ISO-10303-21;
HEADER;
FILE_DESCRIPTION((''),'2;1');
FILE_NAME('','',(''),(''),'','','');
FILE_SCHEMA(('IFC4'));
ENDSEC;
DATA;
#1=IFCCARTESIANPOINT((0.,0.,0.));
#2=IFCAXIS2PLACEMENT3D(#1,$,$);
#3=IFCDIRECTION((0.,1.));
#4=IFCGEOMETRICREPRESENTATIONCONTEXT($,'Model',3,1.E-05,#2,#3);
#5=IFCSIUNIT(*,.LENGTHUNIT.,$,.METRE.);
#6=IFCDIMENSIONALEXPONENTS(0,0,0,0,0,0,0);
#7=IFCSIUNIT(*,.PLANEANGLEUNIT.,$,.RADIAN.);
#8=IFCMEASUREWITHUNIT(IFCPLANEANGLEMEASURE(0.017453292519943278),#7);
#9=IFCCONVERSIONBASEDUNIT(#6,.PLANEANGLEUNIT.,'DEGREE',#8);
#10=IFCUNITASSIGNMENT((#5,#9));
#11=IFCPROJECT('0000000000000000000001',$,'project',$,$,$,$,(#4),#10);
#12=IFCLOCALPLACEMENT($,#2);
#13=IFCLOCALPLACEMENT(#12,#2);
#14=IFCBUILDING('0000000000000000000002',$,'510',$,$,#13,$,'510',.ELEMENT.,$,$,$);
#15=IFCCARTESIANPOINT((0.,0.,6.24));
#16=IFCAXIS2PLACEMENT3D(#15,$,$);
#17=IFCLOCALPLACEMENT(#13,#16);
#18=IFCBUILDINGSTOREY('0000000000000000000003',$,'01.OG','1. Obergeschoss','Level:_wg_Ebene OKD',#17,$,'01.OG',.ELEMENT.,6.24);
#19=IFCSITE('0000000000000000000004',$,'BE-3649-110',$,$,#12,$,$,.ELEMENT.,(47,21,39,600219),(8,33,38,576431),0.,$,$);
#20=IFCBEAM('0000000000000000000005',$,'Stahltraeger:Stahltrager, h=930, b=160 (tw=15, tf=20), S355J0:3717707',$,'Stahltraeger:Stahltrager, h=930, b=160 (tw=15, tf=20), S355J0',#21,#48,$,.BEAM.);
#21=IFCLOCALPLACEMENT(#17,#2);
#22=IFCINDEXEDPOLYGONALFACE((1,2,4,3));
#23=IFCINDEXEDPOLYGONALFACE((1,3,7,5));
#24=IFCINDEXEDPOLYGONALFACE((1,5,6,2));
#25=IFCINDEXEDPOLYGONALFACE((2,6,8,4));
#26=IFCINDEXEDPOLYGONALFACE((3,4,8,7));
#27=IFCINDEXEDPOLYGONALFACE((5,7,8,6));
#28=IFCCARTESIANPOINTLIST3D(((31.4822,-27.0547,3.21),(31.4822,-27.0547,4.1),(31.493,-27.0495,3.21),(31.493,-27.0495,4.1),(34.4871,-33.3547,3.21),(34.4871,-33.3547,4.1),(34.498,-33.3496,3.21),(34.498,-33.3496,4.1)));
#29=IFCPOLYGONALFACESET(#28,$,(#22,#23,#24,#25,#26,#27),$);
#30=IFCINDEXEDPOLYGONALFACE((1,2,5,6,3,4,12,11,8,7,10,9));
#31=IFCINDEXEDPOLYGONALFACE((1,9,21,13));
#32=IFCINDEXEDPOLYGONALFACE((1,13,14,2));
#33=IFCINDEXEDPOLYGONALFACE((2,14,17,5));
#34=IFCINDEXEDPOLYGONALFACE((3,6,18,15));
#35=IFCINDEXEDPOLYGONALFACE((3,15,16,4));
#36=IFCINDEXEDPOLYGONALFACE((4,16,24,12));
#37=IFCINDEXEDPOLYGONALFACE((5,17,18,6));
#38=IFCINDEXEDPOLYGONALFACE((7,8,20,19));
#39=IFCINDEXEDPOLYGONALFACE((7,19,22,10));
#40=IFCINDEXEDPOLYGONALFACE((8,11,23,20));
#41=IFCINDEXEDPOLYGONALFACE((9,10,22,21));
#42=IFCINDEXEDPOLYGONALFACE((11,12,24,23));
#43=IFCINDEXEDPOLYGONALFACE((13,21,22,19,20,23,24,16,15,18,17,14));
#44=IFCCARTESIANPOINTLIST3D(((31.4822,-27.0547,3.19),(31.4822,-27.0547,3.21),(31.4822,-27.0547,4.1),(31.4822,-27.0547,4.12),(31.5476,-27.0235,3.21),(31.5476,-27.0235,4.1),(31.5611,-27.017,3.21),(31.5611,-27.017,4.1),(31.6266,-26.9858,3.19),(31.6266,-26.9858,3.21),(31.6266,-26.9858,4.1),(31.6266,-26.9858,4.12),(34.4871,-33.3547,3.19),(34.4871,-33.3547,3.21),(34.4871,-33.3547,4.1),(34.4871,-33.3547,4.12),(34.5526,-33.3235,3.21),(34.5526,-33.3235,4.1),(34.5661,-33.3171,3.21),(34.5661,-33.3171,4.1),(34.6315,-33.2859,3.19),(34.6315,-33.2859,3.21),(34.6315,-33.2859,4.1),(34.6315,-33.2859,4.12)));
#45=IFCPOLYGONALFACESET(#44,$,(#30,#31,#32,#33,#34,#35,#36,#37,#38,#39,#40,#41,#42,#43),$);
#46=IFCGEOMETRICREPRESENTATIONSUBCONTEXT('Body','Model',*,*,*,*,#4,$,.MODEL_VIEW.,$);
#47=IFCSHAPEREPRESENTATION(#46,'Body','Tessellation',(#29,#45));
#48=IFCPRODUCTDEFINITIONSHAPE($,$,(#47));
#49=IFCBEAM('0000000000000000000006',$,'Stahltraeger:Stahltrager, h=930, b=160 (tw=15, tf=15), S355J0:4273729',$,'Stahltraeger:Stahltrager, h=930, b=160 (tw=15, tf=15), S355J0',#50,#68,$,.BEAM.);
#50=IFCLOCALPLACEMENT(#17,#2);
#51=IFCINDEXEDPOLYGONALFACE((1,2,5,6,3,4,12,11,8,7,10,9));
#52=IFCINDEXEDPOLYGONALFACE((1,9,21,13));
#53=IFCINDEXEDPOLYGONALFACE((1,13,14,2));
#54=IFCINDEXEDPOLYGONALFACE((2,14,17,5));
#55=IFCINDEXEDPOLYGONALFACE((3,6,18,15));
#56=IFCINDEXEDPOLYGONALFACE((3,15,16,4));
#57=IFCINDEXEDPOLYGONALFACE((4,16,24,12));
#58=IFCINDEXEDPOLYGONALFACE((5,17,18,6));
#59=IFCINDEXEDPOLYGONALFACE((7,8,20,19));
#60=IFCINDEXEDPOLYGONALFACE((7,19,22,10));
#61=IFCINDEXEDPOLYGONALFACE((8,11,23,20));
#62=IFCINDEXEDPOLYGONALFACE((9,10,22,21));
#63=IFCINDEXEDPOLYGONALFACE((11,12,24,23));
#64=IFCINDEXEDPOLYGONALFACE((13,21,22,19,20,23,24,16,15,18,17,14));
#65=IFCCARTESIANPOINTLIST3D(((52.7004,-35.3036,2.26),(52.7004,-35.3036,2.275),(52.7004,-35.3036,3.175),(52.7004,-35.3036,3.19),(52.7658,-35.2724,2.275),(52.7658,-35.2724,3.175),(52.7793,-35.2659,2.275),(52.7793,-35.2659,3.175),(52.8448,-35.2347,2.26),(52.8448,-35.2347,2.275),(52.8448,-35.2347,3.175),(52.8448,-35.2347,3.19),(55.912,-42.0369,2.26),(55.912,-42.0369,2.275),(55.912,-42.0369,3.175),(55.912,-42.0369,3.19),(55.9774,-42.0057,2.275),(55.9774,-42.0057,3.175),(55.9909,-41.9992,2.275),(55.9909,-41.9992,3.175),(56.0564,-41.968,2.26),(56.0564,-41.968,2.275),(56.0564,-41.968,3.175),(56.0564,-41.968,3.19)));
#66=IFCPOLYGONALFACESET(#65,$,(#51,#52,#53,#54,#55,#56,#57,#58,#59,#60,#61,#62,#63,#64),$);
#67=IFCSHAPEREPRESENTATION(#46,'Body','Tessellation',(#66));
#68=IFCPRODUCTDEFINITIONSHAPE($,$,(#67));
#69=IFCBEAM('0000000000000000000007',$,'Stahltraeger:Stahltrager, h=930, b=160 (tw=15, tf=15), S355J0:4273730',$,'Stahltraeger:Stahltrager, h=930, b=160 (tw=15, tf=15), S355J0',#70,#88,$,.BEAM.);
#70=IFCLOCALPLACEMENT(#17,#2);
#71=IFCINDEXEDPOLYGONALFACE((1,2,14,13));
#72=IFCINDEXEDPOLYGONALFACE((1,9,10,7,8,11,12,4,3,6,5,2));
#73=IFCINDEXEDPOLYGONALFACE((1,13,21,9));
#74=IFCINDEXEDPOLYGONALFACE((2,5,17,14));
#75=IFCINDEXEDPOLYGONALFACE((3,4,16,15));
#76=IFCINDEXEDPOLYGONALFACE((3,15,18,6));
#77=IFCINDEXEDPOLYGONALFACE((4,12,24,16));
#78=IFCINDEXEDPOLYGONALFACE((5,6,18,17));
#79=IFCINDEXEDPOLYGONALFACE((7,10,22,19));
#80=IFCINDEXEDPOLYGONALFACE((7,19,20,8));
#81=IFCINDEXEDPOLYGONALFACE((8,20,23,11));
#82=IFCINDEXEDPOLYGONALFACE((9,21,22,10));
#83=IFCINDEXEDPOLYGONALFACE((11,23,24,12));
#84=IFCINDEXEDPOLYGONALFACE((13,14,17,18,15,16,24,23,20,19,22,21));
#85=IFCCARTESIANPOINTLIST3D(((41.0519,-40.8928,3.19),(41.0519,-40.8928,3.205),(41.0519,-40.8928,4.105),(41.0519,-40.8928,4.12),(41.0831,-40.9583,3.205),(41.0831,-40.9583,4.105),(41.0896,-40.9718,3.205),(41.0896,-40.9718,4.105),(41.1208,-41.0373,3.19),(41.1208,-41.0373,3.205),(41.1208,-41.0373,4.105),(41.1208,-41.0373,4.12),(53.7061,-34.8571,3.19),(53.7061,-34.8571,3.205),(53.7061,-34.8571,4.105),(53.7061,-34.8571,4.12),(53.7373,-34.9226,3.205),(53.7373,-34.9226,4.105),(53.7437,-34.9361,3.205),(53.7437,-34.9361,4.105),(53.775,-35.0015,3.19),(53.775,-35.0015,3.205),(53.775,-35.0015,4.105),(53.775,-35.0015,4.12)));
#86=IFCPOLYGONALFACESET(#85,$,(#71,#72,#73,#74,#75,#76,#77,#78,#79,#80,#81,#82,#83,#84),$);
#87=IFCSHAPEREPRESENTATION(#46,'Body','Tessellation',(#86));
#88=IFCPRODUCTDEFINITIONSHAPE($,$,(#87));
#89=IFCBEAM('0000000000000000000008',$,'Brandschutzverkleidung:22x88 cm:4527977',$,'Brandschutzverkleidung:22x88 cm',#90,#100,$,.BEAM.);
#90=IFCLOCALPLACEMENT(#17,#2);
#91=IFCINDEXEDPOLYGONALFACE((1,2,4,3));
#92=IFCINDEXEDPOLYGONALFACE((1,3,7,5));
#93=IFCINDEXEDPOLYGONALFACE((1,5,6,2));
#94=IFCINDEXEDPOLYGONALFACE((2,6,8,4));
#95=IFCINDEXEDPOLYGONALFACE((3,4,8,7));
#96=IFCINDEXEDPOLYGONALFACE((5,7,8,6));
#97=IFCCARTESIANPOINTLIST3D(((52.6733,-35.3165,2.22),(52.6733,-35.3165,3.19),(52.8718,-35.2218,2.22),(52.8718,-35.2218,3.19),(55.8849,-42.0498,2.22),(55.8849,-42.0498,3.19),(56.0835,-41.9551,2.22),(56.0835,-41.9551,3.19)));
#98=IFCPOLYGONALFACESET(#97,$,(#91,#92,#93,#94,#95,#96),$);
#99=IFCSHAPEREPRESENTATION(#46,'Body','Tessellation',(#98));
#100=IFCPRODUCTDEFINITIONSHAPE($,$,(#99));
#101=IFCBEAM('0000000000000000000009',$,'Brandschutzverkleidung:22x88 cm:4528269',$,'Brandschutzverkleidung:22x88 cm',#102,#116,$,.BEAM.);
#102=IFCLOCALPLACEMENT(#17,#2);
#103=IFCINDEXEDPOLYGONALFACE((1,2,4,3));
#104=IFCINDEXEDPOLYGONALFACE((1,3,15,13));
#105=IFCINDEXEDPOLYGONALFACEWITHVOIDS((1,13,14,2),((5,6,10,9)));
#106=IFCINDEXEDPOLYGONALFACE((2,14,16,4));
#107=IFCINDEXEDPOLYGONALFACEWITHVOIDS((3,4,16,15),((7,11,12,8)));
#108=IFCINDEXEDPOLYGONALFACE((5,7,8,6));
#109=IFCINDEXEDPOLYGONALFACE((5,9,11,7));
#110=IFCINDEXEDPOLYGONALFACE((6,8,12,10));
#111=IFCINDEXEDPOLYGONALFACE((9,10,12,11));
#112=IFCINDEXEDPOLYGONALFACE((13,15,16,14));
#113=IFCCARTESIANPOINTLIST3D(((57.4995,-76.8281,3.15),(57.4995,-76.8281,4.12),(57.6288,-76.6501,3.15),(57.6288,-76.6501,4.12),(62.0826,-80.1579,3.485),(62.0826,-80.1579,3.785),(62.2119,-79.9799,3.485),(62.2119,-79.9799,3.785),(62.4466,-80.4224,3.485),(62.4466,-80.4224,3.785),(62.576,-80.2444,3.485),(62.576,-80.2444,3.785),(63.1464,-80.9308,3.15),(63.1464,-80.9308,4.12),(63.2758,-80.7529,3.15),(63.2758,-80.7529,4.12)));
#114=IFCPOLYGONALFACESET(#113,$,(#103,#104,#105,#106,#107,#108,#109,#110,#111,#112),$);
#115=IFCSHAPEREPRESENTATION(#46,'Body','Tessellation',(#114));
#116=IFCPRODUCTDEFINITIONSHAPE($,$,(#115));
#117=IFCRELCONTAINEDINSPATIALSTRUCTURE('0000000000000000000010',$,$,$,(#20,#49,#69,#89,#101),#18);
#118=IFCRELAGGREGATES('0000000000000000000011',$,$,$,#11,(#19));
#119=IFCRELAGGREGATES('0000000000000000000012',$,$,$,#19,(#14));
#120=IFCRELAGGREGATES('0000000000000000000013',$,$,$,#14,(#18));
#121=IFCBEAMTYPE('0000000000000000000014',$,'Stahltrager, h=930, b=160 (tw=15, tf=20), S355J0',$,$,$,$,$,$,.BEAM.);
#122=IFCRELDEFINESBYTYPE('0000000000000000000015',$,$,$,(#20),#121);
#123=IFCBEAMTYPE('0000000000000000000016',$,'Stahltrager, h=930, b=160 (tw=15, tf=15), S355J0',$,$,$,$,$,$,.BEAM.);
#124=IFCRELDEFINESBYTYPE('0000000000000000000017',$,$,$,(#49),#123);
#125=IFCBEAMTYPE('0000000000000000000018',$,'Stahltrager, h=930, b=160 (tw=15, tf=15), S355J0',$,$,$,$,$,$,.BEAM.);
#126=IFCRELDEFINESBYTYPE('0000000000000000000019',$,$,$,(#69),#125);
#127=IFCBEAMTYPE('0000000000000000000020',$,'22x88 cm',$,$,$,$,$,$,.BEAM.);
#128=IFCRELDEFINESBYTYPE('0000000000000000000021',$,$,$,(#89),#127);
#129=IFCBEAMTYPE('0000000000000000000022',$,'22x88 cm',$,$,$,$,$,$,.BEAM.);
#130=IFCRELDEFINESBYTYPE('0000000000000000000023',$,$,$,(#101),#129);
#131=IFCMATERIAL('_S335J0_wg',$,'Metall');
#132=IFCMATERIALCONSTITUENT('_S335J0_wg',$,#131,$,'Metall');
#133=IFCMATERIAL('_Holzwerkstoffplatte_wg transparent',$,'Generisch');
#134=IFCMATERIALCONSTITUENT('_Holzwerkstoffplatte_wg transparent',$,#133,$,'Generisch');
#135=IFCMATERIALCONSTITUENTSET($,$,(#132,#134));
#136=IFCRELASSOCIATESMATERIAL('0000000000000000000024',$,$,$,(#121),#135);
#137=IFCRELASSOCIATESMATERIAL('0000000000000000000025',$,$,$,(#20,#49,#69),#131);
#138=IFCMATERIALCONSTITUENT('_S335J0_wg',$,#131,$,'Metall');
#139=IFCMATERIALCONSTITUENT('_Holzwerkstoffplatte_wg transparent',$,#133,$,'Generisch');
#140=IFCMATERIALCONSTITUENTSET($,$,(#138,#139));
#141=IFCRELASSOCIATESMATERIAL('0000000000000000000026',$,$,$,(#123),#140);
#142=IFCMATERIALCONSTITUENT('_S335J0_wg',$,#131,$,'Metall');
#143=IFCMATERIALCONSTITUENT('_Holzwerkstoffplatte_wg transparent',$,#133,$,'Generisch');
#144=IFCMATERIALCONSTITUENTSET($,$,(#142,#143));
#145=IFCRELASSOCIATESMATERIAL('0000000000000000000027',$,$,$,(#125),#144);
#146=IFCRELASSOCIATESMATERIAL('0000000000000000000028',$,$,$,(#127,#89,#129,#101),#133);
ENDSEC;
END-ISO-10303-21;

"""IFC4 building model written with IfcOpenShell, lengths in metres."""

from ifc_helpers import new_model, entity, si_unit, converted_unit, direction, frame, origin, place, context, subcontext, project, spatial, indexed_curve, outline, extrude, source, transform, mapped, material, constituent, constituent_set, type_object, type_shapes, element, save


model = new_model("IFC4")

# Units and contexts
model_context = context("Model", 3, precision=1e-05, world=origin(), true_north=direction((0.0, 1.0)))
body_context = subcontext(model_context, "Body", "Model", "MODEL_VIEW")
ifc_project = project(units=[si_unit("LENGTHUNIT", "METRE"), converted_unit("PLANEANGLEUNIT", "DEGREE", entity("IfcPlaneAngleMeasure", 0.017453292519943278), si_unit("PLANEANGLEUNIT", "RADIAN"), dimensions=[0, 0, 0, 0, 0, 0, 0])], contexts=[model_context])

# Site, building, storey
site_placement = place(None, origin())
site = spatial("IfcSite", under=ifc_project, at=site_placement, Name="BE-3649-110", CompositionType="ELEMENT", RefLatitude=(47, 21, 39, 600219), RefLongitude=(8, 33, 38, 576431), RefElevation=0.0)
building_placement = place(site_placement, origin())
building = spatial("IfcBuilding", under=site, at=building_placement, Name="510", LongName="510", CompositionType="ELEMENT")
storey_placement = place(building_placement, frame((0.0, 0.0, 6.24)))
storey = spatial("IfcBuildingStorey", under=building, at=storey_placement, Name="01.OG", Description="1. Obergeschoss", ObjectType="Level:_wg_Ebene OKD", LongName="01.OG", CompositionType="ELEMENT", Elevation=6.24)

# Beams
ifc_material_1 = material(Name="_S335J0_wg", Category="Metall")
ifc_constituent_1 = constituent(ifc_material_1, Name="_S335J0_wg", Category="Metall")
ifc_material_2 = material(Name="_Holzwerkstoffplatte_wg transparent", Category="Generisch")
ifc_constituent_2 = constituent(ifc_material_2, Name="_Holzwerkstoffplatte_wg transparent", Category="Generisch")
ifc_constituent_set_1 = constituent_set(constituents=[ifc_constituent_1, ifc_constituent_2])
beam_type_1 = type_object("IfcBeamType", Name="Stahltrager, h=930, b=160 (tw=15, tf=20), S355J0", PredefinedType="BEAM", material=ifc_constituent_set_1)
shared_shape_1 = source(origin(), body_context, "Body", "SweptSolid", [
    extrude(outline(indexed_curve([(-0.445, -0.006), (0.445, -0.006), (0.445, 0.006), (-0.445, 0.006), (-0.445, -0.006)], self_intersect=False)), frame((31.4876, -27.0521, 9.895), z_axis=(0.430511, -0.902585, 0.0), x_axis=(0.0, 0.0, -1.0)), (0.0, 0.0, 1.0), 6.98),
    extrude(outline(indexed_curve([(-0.465, -0.08), (-0.445, -0.08), (-0.445, -0.0075), (0.445, -0.0075), (0.445, -0.08), (0.465, -0.08), (0.465, 0.08), (0.445, 0.08), (0.445, 0.0075), (-0.445, 0.0075), (-0.445, 0.08), (-0.465, 0.08), (-0.465, -0.08)], self_intersect=False)), frame((31.5544, -27.0203, 9.895), z_axis=(0.430511, -0.902585, 0.0), x_axis=(0.0, 0.0, -1.0)), (0.0, 0.0, 1.0), 6.98),
])
type_shapes(beam_type_1, [shared_shape_1])
beam_1_placement = place(storey_placement, frame((0.0, 0.0, -6.24)))
element("IfcBeam", 1, at=beam_1_placement, inside=storey, type_object=beam_type_1, material=ifc_material_1, Name="Stahltraeger:Stahltrager, h=930, b=160 (tw=15, tf=20), S355J0:3717707", ObjectType="Stahltraeger:Stahltrager, h=930, b=160 (tw=15, tf=20), S355J0", PredefinedType="BEAM", context=body_context, shape_type="MappedRepresentation", body=[
    mapped(shared_shape_1, transform((0.0, 0.0, 0.0), scale=1.0)),
])
ifc_constituent_3 = constituent(ifc_material_1, Name="_S335J0_wg", Category="Metall")
ifc_constituent_4 = constituent(ifc_material_2, Name="_Holzwerkstoffplatte_wg transparent", Category="Generisch")
ifc_constituent_set_2 = constituent_set(constituents=[ifc_constituent_3, ifc_constituent_4])
beam_type_2 = type_object("IfcBeamType", Name="Stahltrager, h=930, b=160 (tw=15, tf=15), S355J0", PredefinedType="BEAM", material=ifc_constituent_set_2)
shared_shape_2 = source(origin(), body_context, "Body", "SweptSolid", [
    extrude(outline(indexed_curve([(-0.465, -0.08), (-0.45, -0.08), (-0.45, -0.0075), (0.45, -0.0075), (0.45, -0.08), (0.465, -0.08), (0.465, 0.08), (0.45, 0.08), (0.45, 0.0075), (-0.45, 0.0075), (-0.45, 0.08), (-0.465, 0.08), (-0.465, -0.08)], self_intersect=False)), frame((52.7726, -35.2691, 8.965), z_axis=(0.430511, -0.902585, 0.0), x_axis=(0.0, 0.0, -1.0)), (0.0, 0.0, 1.0), 7.46),
])
type_shapes(beam_type_2, [shared_shape_2])
beam_2_placement = place(storey_placement, frame((0.0, 0.0, -6.24)))
element("IfcBeam", 2, at=beam_2_placement, inside=storey, type_object=beam_type_2, material=ifc_material_1, Name="Stahltraeger:Stahltrager, h=930, b=160 (tw=15, tf=15), S355J0:4273729", ObjectType="Stahltraeger:Stahltrager, h=930, b=160 (tw=15, tf=15), S355J0", PredefinedType="BEAM", context=body_context, shape_type="MappedRepresentation", body=[
    mapped(shared_shape_2, transform((0.0, 0.0, 0.0), scale=1.0)),
])
ifc_constituent_5 = constituent(ifc_material_1, Name="_S335J0_wg", Category="Metall")
ifc_constituent_6 = constituent(ifc_material_2, Name="_Holzwerkstoffplatte_wg transparent", Category="Generisch")
ifc_constituent_set_3 = constituent_set(constituents=[ifc_constituent_5, ifc_constituent_6])
beam_type_3 = type_object("IfcBeamType", Name="Stahltrager, h=930, b=160 (tw=15, tf=15), S355J0", PredefinedType="BEAM", material=ifc_constituent_set_3)
shared_shape_3 = source(origin(), body_context, "Body", "SweptSolid", [
    extrude(outline(indexed_curve([(0.45, -0.08), (0.465, -0.08), (0.465, 0.08), (0.45, 0.08), (0.45, 0.0075), (-0.45, 0.0075), (-0.45, 0.08), (-0.465, 0.08), (-0.465, -0.08), (-0.45, -0.08), (-0.45, -0.0075), (0.45, -0.0075), (0.45, -0.08)], self_intersect=False)), frame((41.0864, -40.9651, 9.895), z_axis=(0.902585, 0.430511, 0.0), x_axis=(0.0, 0.0, 1.0)), (0.0, 0.0, 1.0), 14.0199),
])
type_shapes(beam_type_3, [shared_shape_3])
beam_3_placement = place(storey_placement, frame((0.0, 0.0, -6.24)))
element("IfcBeam", 3, at=beam_3_placement, inside=storey, type_object=beam_type_3, material=ifc_material_1, Name="Stahltraeger:Stahltrager, h=930, b=160 (tw=15, tf=15), S355J0:4273730", ObjectType="Stahltraeger:Stahltrager, h=930, b=160 (tw=15, tf=15), S355J0", PredefinedType="BEAM", context=body_context, shape_type="MappedRepresentation", body=[
    mapped(shared_shape_3, transform((0.0, 0.0, 0.0), scale=1.0)),
])

# Beam
beam_type_4 = type_object("IfcBeamType", Name="22x88 cm", PredefinedType="BEAM", material=ifc_material_2)
shared_shape_4 = source(origin(), body_context, "Body", "SweptSolid", [
    extrude(outline(indexed_curve([(-3.73, -0.11), (3.73, -0.11), (3.73, 0.11), (-3.73, 0.11), (-3.73, -0.11)], self_intersect=False)), frame((54.3784, -38.6358, -0.485), z_axis=(0.0, 0.0, 1.0), x_axis=(0.430511, -0.902585, 0.0)), (0.0, 0.0, 1.0), 0.97),
])
type_shapes(beam_type_4, [shared_shape_4])
beam_4_placement = place(storey_placement, frame((0.0, 0.0, 2.705)))
element("IfcBeam", 4, at=beam_4_placement, inside=storey, type_object=beam_type_4, material=ifc_material_2, Name="Brandschutzverkleidung:22x88 cm:4527977", ObjectType="Brandschutzverkleidung:22x88 cm", PredefinedType="BEAM", context=body_context, shape_type="MappedRepresentation", body=[
    mapped(shared_shape_4, transform((0.0, 0.0, 0.0), scale=1.0)),
])

# Beam
beam_type_5 = type_object("IfcBeamType", Name="22x88 cm", PredefinedType="BEAM", material=ifc_material_2)
shared_shape_5 = source(origin(), body_context, "Body", "SweptSolid", [
    extrude(outline(indexed_curve([(-3.49, -0.485), (3.49, -0.485), (3.49, 0.485), (-3.49, 0.485), (-3.49, -0.485)], self_intersect=False), holes=[indexed_curve([(2.175, -0.15), (2.175, 0.15), (2.625, 0.15), (2.625, -0.15), (2.175, -0.15)], self_intersect=False)]), frame((60.323, -78.8795, 0.0), z_axis=(0.587785, 0.809017, 0.0), x_axis=(0.809017, -0.587785, 0.0)), (0.0, 0.0, 1.0), 0.22),
])
type_shapes(beam_type_5, [shared_shape_5])
beam_5_placement = place(storey_placement, frame((0.0, 0.0, 3.635)))
element("IfcBeam", 5, at=beam_5_placement, inside=storey, type_object=beam_type_5, material=ifc_material_2, Name="Brandschutzverkleidung:22x88 cm:4528269", ObjectType="Brandschutzverkleidung:22x88 cm", PredefinedType="BEAM", context=body_context, shape_type="MappedRepresentation", body=[
    mapped(shared_shape_5, transform((0.0, 0.0, 0.0), scale=1.0)),
])

save(model, "model.ifc")
